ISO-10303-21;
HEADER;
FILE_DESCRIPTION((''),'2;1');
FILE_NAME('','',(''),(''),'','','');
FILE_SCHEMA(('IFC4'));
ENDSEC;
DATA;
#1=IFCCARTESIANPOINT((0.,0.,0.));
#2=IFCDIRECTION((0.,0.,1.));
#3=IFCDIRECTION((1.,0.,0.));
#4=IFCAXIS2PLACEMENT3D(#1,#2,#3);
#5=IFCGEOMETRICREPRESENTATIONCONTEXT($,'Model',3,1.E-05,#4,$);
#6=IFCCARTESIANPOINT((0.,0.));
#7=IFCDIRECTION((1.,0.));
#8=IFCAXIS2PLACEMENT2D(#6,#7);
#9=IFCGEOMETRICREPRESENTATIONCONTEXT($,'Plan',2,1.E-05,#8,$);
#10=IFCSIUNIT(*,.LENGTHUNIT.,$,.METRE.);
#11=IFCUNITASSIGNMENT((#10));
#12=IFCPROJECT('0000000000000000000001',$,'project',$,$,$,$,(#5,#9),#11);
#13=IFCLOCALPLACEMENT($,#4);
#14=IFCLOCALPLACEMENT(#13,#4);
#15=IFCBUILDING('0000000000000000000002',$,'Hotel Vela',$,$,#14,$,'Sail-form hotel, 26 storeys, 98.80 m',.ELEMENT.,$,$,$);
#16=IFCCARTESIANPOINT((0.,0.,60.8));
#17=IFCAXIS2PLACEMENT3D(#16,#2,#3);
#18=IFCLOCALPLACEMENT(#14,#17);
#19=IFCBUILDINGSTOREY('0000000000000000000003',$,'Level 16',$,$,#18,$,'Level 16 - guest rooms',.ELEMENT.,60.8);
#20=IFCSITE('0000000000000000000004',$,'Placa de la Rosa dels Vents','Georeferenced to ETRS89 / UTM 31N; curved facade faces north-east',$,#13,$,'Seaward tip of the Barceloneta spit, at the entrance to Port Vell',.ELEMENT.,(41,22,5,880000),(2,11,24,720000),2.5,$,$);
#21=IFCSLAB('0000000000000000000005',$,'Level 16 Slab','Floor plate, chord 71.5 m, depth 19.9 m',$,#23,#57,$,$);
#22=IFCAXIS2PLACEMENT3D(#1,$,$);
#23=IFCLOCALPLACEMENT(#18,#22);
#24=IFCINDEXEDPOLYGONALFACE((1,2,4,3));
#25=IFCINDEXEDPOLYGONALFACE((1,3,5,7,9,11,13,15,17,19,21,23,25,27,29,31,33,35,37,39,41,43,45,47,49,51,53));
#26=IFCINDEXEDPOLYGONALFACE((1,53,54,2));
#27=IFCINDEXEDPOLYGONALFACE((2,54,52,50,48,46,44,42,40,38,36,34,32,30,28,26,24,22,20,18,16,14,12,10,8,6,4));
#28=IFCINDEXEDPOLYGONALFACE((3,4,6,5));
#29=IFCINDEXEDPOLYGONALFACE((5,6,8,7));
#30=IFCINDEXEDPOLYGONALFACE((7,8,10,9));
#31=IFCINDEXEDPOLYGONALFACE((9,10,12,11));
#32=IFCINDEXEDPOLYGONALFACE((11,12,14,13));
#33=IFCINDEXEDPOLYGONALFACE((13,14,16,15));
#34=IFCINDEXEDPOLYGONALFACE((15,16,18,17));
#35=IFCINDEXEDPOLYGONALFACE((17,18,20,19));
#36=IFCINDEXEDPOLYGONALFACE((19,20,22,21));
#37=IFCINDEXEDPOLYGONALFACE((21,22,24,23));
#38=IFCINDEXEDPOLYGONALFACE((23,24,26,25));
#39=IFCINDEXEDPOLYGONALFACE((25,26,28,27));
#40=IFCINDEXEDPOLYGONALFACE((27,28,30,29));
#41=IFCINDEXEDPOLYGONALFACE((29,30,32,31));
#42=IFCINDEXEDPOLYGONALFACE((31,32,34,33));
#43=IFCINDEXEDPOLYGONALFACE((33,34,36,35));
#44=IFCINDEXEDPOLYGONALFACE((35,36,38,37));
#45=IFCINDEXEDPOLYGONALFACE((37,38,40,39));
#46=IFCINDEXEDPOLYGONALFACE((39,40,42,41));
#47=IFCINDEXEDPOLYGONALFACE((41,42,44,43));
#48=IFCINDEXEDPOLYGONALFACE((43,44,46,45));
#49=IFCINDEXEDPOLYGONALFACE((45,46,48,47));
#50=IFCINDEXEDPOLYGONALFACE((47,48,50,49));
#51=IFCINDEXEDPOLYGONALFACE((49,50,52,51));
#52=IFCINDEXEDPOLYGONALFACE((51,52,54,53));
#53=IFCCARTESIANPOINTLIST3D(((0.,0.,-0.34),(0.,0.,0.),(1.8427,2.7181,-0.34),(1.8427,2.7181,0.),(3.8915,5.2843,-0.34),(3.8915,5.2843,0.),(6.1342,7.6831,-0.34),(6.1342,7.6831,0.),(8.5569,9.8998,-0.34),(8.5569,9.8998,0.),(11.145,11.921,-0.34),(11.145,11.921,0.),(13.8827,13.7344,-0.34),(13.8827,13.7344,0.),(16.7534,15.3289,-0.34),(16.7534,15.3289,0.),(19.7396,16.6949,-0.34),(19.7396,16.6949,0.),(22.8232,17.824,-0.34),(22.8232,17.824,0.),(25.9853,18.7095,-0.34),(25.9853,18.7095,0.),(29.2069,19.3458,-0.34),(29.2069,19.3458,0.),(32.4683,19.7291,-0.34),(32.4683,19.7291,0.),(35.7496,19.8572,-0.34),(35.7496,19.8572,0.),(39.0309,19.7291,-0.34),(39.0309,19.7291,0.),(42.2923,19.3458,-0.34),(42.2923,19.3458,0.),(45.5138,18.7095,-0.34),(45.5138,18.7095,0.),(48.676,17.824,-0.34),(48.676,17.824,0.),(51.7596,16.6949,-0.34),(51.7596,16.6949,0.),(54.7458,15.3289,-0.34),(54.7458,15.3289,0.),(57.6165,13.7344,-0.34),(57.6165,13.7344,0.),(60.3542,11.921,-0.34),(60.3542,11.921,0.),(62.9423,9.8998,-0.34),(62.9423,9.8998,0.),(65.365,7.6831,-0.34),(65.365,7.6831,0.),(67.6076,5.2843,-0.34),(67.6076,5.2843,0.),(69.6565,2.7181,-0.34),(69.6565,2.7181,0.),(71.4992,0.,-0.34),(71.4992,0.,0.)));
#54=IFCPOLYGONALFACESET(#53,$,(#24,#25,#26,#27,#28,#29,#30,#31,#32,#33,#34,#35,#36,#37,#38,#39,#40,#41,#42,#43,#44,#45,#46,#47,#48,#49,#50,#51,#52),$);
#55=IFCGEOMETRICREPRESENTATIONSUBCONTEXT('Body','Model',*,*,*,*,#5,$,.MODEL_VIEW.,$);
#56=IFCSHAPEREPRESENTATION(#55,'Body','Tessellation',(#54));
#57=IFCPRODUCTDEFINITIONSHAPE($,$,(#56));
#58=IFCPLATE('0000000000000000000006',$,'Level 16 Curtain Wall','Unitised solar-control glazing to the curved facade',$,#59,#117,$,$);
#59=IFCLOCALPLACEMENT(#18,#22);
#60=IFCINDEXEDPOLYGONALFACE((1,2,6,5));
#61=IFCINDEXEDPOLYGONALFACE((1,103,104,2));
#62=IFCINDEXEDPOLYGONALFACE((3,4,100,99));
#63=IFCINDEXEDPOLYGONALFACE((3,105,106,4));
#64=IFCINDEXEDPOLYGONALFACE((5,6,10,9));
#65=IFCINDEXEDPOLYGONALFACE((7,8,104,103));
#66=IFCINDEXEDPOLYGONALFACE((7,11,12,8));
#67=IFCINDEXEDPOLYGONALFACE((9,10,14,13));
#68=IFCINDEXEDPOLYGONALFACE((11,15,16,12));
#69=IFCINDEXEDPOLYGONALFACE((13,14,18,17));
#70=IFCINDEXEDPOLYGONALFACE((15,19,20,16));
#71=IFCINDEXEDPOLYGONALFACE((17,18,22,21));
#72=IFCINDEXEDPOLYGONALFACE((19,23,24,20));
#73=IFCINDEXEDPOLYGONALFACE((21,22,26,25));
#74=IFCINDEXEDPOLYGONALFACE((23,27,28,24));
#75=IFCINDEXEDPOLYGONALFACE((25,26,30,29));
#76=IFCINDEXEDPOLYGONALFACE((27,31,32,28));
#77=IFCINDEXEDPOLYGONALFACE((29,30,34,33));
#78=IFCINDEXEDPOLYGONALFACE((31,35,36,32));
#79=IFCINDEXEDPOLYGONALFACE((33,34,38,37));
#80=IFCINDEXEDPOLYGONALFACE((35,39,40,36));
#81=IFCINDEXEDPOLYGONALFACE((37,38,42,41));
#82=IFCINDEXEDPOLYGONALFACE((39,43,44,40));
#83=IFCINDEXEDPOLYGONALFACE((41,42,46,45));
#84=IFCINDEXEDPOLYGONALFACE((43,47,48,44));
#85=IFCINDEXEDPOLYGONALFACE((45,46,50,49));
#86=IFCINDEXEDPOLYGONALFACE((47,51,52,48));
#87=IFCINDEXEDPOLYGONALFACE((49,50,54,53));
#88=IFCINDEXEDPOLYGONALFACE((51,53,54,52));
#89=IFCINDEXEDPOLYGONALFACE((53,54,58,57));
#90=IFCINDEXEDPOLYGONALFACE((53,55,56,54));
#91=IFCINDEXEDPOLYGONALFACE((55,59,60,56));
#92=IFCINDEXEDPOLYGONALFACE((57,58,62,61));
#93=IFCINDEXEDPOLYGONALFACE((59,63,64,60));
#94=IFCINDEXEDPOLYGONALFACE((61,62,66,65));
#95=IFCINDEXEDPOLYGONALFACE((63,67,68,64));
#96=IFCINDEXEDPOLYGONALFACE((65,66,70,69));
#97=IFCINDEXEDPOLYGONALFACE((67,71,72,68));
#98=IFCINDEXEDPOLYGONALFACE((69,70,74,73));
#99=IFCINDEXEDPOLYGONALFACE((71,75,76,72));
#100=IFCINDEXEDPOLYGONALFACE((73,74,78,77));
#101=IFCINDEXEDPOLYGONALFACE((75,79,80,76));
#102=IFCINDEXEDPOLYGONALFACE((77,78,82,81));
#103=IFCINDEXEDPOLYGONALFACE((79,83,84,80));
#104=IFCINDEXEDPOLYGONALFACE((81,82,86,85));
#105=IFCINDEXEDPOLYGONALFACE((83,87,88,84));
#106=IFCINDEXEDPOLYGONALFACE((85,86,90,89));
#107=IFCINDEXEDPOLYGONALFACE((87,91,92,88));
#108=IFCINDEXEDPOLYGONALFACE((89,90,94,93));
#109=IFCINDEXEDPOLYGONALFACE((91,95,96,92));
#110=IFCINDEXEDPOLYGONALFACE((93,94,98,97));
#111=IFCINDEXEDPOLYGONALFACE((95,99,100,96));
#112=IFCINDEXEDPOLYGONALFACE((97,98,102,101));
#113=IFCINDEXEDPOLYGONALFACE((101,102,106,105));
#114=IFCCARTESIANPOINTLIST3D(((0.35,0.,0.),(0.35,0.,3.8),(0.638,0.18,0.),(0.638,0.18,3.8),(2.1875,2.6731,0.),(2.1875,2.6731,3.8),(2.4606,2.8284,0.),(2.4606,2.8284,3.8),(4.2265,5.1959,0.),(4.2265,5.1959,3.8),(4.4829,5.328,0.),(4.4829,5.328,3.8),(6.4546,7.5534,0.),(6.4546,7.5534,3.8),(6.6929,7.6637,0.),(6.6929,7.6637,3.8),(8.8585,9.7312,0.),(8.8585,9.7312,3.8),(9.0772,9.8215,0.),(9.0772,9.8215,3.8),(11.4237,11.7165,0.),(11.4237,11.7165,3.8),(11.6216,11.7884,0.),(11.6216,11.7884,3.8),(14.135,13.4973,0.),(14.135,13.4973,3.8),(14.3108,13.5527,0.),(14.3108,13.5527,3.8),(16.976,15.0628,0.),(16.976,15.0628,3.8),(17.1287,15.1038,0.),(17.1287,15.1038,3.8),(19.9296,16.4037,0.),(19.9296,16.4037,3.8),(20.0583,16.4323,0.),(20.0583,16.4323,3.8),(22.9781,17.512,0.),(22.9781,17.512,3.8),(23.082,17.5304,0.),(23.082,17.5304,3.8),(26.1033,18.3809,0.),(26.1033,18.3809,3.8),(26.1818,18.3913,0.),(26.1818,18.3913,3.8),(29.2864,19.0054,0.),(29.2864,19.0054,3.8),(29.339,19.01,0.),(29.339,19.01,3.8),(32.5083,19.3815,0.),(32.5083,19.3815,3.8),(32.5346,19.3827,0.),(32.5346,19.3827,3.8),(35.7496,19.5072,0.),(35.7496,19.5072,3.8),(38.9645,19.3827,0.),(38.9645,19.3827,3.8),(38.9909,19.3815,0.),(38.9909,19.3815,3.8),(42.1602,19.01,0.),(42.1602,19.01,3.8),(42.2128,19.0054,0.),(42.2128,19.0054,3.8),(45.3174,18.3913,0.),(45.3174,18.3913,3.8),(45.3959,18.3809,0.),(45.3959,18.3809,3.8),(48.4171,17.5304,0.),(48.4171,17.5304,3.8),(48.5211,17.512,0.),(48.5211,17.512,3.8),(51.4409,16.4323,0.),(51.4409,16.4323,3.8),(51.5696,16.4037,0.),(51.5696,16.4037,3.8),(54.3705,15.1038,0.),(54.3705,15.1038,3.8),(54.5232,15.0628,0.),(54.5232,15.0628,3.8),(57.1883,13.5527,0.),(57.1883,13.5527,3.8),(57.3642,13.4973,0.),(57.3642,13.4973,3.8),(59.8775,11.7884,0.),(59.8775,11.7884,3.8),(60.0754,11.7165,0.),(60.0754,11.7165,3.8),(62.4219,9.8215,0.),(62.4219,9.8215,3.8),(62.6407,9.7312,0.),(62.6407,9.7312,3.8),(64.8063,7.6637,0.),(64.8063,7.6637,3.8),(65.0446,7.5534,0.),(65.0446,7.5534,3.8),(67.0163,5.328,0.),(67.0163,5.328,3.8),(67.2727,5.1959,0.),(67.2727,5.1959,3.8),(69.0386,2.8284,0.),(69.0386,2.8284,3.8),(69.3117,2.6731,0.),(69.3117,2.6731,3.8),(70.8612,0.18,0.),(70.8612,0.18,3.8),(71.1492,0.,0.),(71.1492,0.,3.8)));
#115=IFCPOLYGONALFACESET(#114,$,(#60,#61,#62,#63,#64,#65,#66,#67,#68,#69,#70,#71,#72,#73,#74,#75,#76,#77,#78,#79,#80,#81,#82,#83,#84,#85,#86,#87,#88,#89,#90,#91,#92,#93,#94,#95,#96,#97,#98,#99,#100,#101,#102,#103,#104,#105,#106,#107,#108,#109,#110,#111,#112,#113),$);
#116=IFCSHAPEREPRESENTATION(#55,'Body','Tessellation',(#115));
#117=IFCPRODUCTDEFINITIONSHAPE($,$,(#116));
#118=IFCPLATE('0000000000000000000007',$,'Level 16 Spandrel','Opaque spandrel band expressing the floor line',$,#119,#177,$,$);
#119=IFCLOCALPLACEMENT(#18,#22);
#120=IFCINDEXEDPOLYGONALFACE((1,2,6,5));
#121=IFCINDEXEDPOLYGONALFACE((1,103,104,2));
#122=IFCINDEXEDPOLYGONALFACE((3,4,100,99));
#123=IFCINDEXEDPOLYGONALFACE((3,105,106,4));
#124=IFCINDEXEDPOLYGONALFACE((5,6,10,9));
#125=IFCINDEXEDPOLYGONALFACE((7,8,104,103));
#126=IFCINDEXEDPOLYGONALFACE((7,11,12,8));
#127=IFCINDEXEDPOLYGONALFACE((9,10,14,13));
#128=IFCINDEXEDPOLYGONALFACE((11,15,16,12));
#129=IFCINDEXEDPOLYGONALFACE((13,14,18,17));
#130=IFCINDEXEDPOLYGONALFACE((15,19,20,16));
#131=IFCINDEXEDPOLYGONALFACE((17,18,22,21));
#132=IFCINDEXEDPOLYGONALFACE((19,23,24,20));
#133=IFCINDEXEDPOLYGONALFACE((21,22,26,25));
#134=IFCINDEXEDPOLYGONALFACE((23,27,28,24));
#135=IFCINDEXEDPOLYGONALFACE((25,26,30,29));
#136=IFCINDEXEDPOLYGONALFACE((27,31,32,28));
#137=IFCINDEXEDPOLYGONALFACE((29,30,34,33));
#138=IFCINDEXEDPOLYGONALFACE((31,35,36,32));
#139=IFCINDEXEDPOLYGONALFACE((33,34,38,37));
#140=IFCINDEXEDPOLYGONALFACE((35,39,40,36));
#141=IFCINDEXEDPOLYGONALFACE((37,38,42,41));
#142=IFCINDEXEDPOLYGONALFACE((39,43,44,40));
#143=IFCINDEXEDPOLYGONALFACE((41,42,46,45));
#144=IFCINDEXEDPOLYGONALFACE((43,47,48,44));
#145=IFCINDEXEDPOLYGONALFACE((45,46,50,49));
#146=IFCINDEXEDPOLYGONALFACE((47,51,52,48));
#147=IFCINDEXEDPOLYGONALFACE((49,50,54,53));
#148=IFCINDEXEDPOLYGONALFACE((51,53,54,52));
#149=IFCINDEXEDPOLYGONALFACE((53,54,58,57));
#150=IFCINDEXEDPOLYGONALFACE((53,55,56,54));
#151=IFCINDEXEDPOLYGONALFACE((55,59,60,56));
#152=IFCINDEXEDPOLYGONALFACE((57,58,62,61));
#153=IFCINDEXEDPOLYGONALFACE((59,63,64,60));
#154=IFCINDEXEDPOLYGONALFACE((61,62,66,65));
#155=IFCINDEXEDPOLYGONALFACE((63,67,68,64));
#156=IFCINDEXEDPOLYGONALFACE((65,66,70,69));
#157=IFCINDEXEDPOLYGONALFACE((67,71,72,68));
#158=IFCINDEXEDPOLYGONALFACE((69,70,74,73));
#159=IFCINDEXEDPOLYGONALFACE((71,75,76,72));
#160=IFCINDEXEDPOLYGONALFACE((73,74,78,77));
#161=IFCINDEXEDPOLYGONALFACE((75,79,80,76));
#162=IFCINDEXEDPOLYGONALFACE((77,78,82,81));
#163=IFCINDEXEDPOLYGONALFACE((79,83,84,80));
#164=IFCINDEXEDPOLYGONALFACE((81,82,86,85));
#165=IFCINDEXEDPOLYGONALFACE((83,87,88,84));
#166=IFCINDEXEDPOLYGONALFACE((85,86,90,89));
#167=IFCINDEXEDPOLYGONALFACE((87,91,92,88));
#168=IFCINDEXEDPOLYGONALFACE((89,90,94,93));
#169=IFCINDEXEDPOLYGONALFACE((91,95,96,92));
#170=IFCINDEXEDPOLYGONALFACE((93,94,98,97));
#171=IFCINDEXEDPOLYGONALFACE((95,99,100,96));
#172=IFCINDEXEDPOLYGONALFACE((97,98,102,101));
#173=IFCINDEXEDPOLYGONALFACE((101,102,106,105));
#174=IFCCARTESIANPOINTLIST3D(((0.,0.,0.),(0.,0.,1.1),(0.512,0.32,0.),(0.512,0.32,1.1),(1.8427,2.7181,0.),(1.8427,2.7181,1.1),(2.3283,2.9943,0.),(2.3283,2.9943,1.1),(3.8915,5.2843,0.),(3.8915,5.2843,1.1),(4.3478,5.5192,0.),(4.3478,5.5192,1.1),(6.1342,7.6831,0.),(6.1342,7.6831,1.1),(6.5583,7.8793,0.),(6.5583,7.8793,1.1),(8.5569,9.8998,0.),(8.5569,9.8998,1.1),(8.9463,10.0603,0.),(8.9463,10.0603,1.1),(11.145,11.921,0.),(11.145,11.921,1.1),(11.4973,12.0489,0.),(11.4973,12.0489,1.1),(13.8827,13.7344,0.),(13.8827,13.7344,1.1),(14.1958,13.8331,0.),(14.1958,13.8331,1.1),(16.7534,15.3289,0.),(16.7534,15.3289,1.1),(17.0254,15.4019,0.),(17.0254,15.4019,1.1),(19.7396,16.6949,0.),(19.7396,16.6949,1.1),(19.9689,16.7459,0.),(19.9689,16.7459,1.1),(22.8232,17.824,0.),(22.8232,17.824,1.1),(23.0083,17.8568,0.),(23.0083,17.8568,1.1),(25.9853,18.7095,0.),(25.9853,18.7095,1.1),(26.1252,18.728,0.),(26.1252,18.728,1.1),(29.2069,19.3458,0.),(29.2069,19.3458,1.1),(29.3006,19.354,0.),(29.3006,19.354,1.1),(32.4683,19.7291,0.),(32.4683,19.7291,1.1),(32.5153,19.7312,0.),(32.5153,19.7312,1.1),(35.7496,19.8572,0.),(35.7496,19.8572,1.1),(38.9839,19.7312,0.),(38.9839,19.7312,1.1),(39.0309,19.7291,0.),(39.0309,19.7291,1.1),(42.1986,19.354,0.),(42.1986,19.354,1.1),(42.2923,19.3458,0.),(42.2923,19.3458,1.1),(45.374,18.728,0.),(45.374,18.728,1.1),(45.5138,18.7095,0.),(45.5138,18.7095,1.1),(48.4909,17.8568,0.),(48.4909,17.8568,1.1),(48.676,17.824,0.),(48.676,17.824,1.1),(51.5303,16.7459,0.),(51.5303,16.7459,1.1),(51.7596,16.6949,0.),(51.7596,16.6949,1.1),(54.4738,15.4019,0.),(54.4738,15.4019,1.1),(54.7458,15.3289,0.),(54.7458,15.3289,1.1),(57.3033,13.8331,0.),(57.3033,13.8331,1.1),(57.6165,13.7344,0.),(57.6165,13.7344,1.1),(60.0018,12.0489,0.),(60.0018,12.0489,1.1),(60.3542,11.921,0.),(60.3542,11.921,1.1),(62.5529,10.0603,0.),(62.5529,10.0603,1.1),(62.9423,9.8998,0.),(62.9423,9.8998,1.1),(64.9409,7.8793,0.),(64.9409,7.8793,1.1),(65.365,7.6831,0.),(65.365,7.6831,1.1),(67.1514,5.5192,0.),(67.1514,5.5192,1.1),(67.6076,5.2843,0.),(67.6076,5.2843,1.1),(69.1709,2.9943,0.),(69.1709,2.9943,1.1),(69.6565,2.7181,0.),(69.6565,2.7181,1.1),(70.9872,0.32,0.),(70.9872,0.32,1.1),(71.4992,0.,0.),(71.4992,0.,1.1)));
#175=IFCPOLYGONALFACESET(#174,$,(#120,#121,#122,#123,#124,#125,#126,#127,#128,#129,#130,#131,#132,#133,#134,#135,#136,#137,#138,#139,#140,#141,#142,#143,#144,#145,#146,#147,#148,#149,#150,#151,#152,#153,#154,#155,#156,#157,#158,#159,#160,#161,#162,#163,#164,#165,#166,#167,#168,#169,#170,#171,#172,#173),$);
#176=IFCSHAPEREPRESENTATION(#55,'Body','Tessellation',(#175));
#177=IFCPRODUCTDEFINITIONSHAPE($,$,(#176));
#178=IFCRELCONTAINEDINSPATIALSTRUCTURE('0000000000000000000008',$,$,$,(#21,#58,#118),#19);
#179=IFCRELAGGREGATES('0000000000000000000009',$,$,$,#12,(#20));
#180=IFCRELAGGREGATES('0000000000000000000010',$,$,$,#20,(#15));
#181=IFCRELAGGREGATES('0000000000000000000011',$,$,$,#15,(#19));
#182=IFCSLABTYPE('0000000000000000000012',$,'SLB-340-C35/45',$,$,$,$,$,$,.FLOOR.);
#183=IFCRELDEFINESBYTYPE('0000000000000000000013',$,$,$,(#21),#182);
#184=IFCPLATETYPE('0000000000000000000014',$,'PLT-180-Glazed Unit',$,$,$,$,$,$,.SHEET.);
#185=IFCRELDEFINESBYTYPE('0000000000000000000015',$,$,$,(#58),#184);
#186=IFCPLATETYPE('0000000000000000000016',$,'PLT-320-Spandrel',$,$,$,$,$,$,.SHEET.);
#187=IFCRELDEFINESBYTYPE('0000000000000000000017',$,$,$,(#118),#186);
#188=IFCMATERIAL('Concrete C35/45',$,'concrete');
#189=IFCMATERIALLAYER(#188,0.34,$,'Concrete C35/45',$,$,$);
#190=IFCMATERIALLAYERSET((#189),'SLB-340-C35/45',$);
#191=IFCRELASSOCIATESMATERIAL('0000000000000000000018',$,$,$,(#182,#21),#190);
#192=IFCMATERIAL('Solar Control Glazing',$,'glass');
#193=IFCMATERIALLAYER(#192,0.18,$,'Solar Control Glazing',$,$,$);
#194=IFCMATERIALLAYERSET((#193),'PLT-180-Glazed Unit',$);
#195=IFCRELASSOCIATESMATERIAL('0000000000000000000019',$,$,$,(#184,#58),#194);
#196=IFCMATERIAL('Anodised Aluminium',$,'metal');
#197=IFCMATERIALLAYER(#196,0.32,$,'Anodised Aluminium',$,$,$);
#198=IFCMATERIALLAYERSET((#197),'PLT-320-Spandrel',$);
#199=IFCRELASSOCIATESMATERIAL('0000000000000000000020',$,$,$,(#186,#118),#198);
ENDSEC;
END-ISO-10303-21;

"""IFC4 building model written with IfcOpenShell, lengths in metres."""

from ifc_helpers import new_model, si_unit, frame, origin_with_axes, origin_2d_with_axis, place, context, subcontext, project, spatial, line, indexed_curve, outline, extrude, material, layer, layer_set, layer_usage, type_object, element, save


model = new_model("IFC4")

# Units and contexts
model_context = context("Model", 3, precision=1e-05, world=origin_with_axes())
plan_context = context("Plan", 2, precision=1e-05, world=origin_2d_with_axis())
body_context = subcontext(model_context, "Body", "Model", "MODEL_VIEW")
ifc_project = project(units=[si_unit("LENGTHUNIT", "METRE")], contexts=[model_context, plan_context])

# Site, building, storey
site_placement = place(None, origin_with_axes())
site = spatial("IfcSite", under=ifc_project, at=site_placement, Name="Placa de la Rosa dels Vents", Description="Georeferenced to ETRS89 / UTM 31N; curved facade faces north-east", LongName="Seaward tip of the Barceloneta spit, at the entrance to Port Vell", CompositionType="ELEMENT", RefLatitude=(41, 22, 5, 880000), RefLongitude=(2, 11, 24, 720000), RefElevation=2.5)
building_placement = place(site_placement, origin_with_axes())
building = spatial("IfcBuilding", under=site, at=building_placement, Name="Hotel Vela", LongName="Sail-form hotel, 26 storeys, 98.80 m", CompositionType="ELEMENT")
storey_placement = place(building_placement, frame((0.0, 0.0, 60.8), z_axis=(0.0, 0.0, 1.0), x_axis=(1.0, 0.0, 0.0)))
storey = spatial("IfcBuildingStorey", under=building, at=storey_placement, Name="Level 16", LongName="Level 16 - guest rooms", CompositionType="ELEMENT", Elevation=60.8)

# Slab
ifc_material_1 = material(Name="Concrete C35/45", Category="concrete")
ifc_layer_1 = layer(ifc_material_1, 0.34, Name="Concrete C35/45")
ifc_layer_set_1 = layer_set([ifc_layer_1], Name="SLB-340-C35/45")
ifc_layer_usage_1 = layer_usage(ifc_layer_set_1, "AXIS3", "POSITIVE", 0.0)
slab_type = type_object("IfcSlabType", Name="SLB-340-C35/45", PredefinedType="FLOOR", material=ifc_layer_set_1)
slab_placement = place(storey_placement, frame((0.0, 0.0, -0.34), z_axis=(0.0, 0.0, 1.0), x_axis=(1.0, 0.0, 0.0)))
element("IfcSlab", 1, at=slab_placement, inside=storey, type_object=slab_type, material=ifc_layer_usage_1, Name="Level 16 Slab", Description="Floor plate, chord 71.5 m, depth 19.9 m", context=body_context, shape_type="SweptSolid", body=[
    extrude(outline(indexed_curve([(0.0, 0.0), (71.4992, 0.0), (69.6565, 2.7181), (67.6076, 5.2843), (65.365, 7.6831), (62.9423, 9.8998), (60.3542, 11.921), (57.6165, 13.7344), (54.7458, 15.3289), (51.7596, 16.6949), (48.676, 17.824), (45.5138, 18.7095), (42.2923, 19.3458), (39.0309, 19.7291), (35.7496, 19.8572), (32.4683, 19.7291), (29.2069, 19.3458), (25.9853, 18.7095), (22.8232, 17.824), (19.7396, 16.6949), (16.7534, 15.3289), (13.8827, 13.7344), (11.145, 11.921), (8.5569, 9.8998), (6.1342, 7.6831), (3.8915, 5.2843), (1.8427, 2.7181)], segments=[line(1, 2, 3, 4, 5, 6, 7, 8, 9, 10, 11, 12, 13, 14, 15, 16, 17, 18, 19, 20, 21, 22, 23, 24, 25, 26, 27, 1)])), origin_with_axes(), (0.0, 0.0, 1.0), 0.34),
])

# Plates
ifc_material_2 = material(Name="Solar Control Glazing", Category="glass")
ifc_layer_2 = layer(ifc_material_2, 0.18, Name="Solar Control Glazing")
ifc_layer_set_2 = layer_set([ifc_layer_2], Name="PLT-180-Glazed Unit")
ifc_layer_usage_2 = layer_usage(ifc_layer_set_2, "AXIS2", "POSITIVE", 0.0)
plate_type_1 = type_object("IfcPlateType", Name="PLT-180-Glazed Unit", PredefinedType="SHEET", material=ifc_layer_set_2)
plate_1_placement = place(storey_placement, frame((0.35, 0.0, 0.0), z_axis=(0.0, 0.0, 1.0), x_axis=(1.0, 0.0, 0.0)))
element("IfcPlate", 2, at=plate_1_placement, inside=storey, type_object=plate_type_1, material=ifc_layer_usage_2, Name="Level 16 Curtain Wall", Description="Unitised solar-control glazing to the curved facade", context=body_context, shape_type="SweptSolid", body=[
    extrude(outline(indexed_curve([(70.7992, 0.0), (68.9617, 2.6731), (66.9227, 5.1959), (64.6946, 7.5534), (62.2907, 9.7312), (59.7254, 11.7165), (57.0142, 13.4973), (54.1732, 15.0628), (51.2196, 16.4037), (48.1711, 17.512), (45.0459, 18.3809), (41.8628, 19.0054), (38.6409, 19.3815), (35.3996, 19.5072), (32.1583, 19.3815), (28.9364, 19.0054), (25.7533, 18.3809), (22.6281, 17.512), (19.5796, 16.4037), (16.626, 15.0628), (13.785, 13.4973), (11.0737, 11.7165), (8.5085, 9.7312), (6.1046, 7.5534), (3.8765, 5.1959), (1.8375, 2.6731), (0.0, 0.0), (70.5112, 0.18), (2.1106, 2.8284), (4.1329, 5.328), (6.3429, 7.6637), (8.7272, 9.8215), (11.2716, 11.7884), (13.9608, 13.5527), (16.7787, 15.1038), (19.7083, 16.4323), (22.732, 17.5304), (25.8318, 18.3913), (28.989, 19.01), (32.1846, 19.3827), (35.3996, 19.5072), (38.6145, 19.3827), (41.8102, 19.01), (44.9674, 18.3913), (48.0671, 17.5304), (51.0909, 16.4323), (54.0205, 15.1038), (56.8383, 13.5527), (59.5275, 11.7884), (62.0719, 9.8215), (64.4563, 7.6637), (66.6663, 5.328), (68.6886, 2.8284), (0.288, 0.18)], segments=[line(1, 2, 3, 4, 5, 6, 7, 8, 9, 10, 11, 12, 13, 14, 15, 16, 17, 18, 19, 20, 21, 22, 23, 24, 25, 26, 27, 28, 29, 30, 31, 32, 33, 34, 35, 36, 37, 38, 39, 40, 41, 42, 43, 44, 45, 46, 47, 48, 49, 50, 51, 52, 53, 54, 1)])), origin_with_axes(), (0.0, 0.0, 1.0), 3.8),
])
ifc_material_3 = material(Name="Anodised Aluminium", Category="metal")
ifc_layer_3 = layer(ifc_material_3, 0.32, Name="Anodised Aluminium")
ifc_layer_set_3 = layer_set([ifc_layer_3], Name="PLT-320-Spandrel")
ifc_layer_usage_3 = layer_usage(ifc_layer_set_3, "AXIS2", "POSITIVE", 0.0)
plate_type_2 = type_object("IfcPlateType", Name="PLT-320-Spandrel", PredefinedType="SHEET", material=ifc_layer_set_3)
plate_2_placement = place(storey_placement, origin_with_axes())
element("IfcPlate", 3, at=plate_2_placement, inside=storey, type_object=plate_type_2, material=ifc_layer_usage_3, Name="Level 16 Spandrel", Description="Opaque spandrel band expressing the floor line", context=body_context, shape_type="SweptSolid", body=[
    extrude(outline(indexed_curve([(71.4992, 0.0), (69.6565, 2.7181), (67.6076, 5.2843), (65.365, 7.6831), (62.9423, 9.8998), (60.3542, 11.921), (57.6165, 13.7344), (54.7458, 15.3289), (51.7596, 16.6949), (48.676, 17.824), (45.5138, 18.7095), (42.2923, 19.3458), (39.0309, 19.7291), (35.7496, 19.8572), (32.4683, 19.7291), (29.2069, 19.3458), (25.9853, 18.7095), (22.8232, 17.824), (19.7396, 16.6949), (16.7534, 15.3289), (13.8827, 13.7344), (11.145, 11.921), (8.5569, 9.8998), (6.1342, 7.6831), (3.8915, 5.2843), (1.8427, 2.7181), (0.0, 0.0), (70.9872, 0.32), (2.3283, 2.9943), (4.3478, 5.5192), (6.5583, 7.8793), (8.9463, 10.0603), (11.4973, 12.0489), (14.1958, 13.8331), (17.0254, 15.4019), (19.9689, 16.7459), (23.0083, 17.8568), (26.1252, 18.728), (29.3006, 19.354), (32.5153, 19.7312), (35.7496, 19.8572), (38.9839, 19.7312), (42.1986, 19.354), (45.374, 18.728), (48.4909, 17.8568), (51.5303, 16.7459), (54.4738, 15.4019), (57.3033, 13.8331), (60.0018, 12.0489), (62.5529, 10.0603), (64.9409, 7.8793), (67.1514, 5.5192), (69.1709, 2.9943), (0.512, 0.32)], segments=[line(1, 2, 3, 4, 5, 6, 7, 8, 9, 10, 11, 12, 13, 14, 15, 16, 17, 18, 19, 20, 21, 22, 23, 24, 25, 26, 27, 28, 29, 30, 31, 32, 33, 34, 35, 36, 37, 38, 39, 40, 41, 42, 43, 44, 45, 46, 47, 48, 49, 50, 51, 52, 53, 54, 1)])), origin_with_axes(), (0.0, 0.0, 1.0), 1.1),
])

save(model, "model.ifc")
